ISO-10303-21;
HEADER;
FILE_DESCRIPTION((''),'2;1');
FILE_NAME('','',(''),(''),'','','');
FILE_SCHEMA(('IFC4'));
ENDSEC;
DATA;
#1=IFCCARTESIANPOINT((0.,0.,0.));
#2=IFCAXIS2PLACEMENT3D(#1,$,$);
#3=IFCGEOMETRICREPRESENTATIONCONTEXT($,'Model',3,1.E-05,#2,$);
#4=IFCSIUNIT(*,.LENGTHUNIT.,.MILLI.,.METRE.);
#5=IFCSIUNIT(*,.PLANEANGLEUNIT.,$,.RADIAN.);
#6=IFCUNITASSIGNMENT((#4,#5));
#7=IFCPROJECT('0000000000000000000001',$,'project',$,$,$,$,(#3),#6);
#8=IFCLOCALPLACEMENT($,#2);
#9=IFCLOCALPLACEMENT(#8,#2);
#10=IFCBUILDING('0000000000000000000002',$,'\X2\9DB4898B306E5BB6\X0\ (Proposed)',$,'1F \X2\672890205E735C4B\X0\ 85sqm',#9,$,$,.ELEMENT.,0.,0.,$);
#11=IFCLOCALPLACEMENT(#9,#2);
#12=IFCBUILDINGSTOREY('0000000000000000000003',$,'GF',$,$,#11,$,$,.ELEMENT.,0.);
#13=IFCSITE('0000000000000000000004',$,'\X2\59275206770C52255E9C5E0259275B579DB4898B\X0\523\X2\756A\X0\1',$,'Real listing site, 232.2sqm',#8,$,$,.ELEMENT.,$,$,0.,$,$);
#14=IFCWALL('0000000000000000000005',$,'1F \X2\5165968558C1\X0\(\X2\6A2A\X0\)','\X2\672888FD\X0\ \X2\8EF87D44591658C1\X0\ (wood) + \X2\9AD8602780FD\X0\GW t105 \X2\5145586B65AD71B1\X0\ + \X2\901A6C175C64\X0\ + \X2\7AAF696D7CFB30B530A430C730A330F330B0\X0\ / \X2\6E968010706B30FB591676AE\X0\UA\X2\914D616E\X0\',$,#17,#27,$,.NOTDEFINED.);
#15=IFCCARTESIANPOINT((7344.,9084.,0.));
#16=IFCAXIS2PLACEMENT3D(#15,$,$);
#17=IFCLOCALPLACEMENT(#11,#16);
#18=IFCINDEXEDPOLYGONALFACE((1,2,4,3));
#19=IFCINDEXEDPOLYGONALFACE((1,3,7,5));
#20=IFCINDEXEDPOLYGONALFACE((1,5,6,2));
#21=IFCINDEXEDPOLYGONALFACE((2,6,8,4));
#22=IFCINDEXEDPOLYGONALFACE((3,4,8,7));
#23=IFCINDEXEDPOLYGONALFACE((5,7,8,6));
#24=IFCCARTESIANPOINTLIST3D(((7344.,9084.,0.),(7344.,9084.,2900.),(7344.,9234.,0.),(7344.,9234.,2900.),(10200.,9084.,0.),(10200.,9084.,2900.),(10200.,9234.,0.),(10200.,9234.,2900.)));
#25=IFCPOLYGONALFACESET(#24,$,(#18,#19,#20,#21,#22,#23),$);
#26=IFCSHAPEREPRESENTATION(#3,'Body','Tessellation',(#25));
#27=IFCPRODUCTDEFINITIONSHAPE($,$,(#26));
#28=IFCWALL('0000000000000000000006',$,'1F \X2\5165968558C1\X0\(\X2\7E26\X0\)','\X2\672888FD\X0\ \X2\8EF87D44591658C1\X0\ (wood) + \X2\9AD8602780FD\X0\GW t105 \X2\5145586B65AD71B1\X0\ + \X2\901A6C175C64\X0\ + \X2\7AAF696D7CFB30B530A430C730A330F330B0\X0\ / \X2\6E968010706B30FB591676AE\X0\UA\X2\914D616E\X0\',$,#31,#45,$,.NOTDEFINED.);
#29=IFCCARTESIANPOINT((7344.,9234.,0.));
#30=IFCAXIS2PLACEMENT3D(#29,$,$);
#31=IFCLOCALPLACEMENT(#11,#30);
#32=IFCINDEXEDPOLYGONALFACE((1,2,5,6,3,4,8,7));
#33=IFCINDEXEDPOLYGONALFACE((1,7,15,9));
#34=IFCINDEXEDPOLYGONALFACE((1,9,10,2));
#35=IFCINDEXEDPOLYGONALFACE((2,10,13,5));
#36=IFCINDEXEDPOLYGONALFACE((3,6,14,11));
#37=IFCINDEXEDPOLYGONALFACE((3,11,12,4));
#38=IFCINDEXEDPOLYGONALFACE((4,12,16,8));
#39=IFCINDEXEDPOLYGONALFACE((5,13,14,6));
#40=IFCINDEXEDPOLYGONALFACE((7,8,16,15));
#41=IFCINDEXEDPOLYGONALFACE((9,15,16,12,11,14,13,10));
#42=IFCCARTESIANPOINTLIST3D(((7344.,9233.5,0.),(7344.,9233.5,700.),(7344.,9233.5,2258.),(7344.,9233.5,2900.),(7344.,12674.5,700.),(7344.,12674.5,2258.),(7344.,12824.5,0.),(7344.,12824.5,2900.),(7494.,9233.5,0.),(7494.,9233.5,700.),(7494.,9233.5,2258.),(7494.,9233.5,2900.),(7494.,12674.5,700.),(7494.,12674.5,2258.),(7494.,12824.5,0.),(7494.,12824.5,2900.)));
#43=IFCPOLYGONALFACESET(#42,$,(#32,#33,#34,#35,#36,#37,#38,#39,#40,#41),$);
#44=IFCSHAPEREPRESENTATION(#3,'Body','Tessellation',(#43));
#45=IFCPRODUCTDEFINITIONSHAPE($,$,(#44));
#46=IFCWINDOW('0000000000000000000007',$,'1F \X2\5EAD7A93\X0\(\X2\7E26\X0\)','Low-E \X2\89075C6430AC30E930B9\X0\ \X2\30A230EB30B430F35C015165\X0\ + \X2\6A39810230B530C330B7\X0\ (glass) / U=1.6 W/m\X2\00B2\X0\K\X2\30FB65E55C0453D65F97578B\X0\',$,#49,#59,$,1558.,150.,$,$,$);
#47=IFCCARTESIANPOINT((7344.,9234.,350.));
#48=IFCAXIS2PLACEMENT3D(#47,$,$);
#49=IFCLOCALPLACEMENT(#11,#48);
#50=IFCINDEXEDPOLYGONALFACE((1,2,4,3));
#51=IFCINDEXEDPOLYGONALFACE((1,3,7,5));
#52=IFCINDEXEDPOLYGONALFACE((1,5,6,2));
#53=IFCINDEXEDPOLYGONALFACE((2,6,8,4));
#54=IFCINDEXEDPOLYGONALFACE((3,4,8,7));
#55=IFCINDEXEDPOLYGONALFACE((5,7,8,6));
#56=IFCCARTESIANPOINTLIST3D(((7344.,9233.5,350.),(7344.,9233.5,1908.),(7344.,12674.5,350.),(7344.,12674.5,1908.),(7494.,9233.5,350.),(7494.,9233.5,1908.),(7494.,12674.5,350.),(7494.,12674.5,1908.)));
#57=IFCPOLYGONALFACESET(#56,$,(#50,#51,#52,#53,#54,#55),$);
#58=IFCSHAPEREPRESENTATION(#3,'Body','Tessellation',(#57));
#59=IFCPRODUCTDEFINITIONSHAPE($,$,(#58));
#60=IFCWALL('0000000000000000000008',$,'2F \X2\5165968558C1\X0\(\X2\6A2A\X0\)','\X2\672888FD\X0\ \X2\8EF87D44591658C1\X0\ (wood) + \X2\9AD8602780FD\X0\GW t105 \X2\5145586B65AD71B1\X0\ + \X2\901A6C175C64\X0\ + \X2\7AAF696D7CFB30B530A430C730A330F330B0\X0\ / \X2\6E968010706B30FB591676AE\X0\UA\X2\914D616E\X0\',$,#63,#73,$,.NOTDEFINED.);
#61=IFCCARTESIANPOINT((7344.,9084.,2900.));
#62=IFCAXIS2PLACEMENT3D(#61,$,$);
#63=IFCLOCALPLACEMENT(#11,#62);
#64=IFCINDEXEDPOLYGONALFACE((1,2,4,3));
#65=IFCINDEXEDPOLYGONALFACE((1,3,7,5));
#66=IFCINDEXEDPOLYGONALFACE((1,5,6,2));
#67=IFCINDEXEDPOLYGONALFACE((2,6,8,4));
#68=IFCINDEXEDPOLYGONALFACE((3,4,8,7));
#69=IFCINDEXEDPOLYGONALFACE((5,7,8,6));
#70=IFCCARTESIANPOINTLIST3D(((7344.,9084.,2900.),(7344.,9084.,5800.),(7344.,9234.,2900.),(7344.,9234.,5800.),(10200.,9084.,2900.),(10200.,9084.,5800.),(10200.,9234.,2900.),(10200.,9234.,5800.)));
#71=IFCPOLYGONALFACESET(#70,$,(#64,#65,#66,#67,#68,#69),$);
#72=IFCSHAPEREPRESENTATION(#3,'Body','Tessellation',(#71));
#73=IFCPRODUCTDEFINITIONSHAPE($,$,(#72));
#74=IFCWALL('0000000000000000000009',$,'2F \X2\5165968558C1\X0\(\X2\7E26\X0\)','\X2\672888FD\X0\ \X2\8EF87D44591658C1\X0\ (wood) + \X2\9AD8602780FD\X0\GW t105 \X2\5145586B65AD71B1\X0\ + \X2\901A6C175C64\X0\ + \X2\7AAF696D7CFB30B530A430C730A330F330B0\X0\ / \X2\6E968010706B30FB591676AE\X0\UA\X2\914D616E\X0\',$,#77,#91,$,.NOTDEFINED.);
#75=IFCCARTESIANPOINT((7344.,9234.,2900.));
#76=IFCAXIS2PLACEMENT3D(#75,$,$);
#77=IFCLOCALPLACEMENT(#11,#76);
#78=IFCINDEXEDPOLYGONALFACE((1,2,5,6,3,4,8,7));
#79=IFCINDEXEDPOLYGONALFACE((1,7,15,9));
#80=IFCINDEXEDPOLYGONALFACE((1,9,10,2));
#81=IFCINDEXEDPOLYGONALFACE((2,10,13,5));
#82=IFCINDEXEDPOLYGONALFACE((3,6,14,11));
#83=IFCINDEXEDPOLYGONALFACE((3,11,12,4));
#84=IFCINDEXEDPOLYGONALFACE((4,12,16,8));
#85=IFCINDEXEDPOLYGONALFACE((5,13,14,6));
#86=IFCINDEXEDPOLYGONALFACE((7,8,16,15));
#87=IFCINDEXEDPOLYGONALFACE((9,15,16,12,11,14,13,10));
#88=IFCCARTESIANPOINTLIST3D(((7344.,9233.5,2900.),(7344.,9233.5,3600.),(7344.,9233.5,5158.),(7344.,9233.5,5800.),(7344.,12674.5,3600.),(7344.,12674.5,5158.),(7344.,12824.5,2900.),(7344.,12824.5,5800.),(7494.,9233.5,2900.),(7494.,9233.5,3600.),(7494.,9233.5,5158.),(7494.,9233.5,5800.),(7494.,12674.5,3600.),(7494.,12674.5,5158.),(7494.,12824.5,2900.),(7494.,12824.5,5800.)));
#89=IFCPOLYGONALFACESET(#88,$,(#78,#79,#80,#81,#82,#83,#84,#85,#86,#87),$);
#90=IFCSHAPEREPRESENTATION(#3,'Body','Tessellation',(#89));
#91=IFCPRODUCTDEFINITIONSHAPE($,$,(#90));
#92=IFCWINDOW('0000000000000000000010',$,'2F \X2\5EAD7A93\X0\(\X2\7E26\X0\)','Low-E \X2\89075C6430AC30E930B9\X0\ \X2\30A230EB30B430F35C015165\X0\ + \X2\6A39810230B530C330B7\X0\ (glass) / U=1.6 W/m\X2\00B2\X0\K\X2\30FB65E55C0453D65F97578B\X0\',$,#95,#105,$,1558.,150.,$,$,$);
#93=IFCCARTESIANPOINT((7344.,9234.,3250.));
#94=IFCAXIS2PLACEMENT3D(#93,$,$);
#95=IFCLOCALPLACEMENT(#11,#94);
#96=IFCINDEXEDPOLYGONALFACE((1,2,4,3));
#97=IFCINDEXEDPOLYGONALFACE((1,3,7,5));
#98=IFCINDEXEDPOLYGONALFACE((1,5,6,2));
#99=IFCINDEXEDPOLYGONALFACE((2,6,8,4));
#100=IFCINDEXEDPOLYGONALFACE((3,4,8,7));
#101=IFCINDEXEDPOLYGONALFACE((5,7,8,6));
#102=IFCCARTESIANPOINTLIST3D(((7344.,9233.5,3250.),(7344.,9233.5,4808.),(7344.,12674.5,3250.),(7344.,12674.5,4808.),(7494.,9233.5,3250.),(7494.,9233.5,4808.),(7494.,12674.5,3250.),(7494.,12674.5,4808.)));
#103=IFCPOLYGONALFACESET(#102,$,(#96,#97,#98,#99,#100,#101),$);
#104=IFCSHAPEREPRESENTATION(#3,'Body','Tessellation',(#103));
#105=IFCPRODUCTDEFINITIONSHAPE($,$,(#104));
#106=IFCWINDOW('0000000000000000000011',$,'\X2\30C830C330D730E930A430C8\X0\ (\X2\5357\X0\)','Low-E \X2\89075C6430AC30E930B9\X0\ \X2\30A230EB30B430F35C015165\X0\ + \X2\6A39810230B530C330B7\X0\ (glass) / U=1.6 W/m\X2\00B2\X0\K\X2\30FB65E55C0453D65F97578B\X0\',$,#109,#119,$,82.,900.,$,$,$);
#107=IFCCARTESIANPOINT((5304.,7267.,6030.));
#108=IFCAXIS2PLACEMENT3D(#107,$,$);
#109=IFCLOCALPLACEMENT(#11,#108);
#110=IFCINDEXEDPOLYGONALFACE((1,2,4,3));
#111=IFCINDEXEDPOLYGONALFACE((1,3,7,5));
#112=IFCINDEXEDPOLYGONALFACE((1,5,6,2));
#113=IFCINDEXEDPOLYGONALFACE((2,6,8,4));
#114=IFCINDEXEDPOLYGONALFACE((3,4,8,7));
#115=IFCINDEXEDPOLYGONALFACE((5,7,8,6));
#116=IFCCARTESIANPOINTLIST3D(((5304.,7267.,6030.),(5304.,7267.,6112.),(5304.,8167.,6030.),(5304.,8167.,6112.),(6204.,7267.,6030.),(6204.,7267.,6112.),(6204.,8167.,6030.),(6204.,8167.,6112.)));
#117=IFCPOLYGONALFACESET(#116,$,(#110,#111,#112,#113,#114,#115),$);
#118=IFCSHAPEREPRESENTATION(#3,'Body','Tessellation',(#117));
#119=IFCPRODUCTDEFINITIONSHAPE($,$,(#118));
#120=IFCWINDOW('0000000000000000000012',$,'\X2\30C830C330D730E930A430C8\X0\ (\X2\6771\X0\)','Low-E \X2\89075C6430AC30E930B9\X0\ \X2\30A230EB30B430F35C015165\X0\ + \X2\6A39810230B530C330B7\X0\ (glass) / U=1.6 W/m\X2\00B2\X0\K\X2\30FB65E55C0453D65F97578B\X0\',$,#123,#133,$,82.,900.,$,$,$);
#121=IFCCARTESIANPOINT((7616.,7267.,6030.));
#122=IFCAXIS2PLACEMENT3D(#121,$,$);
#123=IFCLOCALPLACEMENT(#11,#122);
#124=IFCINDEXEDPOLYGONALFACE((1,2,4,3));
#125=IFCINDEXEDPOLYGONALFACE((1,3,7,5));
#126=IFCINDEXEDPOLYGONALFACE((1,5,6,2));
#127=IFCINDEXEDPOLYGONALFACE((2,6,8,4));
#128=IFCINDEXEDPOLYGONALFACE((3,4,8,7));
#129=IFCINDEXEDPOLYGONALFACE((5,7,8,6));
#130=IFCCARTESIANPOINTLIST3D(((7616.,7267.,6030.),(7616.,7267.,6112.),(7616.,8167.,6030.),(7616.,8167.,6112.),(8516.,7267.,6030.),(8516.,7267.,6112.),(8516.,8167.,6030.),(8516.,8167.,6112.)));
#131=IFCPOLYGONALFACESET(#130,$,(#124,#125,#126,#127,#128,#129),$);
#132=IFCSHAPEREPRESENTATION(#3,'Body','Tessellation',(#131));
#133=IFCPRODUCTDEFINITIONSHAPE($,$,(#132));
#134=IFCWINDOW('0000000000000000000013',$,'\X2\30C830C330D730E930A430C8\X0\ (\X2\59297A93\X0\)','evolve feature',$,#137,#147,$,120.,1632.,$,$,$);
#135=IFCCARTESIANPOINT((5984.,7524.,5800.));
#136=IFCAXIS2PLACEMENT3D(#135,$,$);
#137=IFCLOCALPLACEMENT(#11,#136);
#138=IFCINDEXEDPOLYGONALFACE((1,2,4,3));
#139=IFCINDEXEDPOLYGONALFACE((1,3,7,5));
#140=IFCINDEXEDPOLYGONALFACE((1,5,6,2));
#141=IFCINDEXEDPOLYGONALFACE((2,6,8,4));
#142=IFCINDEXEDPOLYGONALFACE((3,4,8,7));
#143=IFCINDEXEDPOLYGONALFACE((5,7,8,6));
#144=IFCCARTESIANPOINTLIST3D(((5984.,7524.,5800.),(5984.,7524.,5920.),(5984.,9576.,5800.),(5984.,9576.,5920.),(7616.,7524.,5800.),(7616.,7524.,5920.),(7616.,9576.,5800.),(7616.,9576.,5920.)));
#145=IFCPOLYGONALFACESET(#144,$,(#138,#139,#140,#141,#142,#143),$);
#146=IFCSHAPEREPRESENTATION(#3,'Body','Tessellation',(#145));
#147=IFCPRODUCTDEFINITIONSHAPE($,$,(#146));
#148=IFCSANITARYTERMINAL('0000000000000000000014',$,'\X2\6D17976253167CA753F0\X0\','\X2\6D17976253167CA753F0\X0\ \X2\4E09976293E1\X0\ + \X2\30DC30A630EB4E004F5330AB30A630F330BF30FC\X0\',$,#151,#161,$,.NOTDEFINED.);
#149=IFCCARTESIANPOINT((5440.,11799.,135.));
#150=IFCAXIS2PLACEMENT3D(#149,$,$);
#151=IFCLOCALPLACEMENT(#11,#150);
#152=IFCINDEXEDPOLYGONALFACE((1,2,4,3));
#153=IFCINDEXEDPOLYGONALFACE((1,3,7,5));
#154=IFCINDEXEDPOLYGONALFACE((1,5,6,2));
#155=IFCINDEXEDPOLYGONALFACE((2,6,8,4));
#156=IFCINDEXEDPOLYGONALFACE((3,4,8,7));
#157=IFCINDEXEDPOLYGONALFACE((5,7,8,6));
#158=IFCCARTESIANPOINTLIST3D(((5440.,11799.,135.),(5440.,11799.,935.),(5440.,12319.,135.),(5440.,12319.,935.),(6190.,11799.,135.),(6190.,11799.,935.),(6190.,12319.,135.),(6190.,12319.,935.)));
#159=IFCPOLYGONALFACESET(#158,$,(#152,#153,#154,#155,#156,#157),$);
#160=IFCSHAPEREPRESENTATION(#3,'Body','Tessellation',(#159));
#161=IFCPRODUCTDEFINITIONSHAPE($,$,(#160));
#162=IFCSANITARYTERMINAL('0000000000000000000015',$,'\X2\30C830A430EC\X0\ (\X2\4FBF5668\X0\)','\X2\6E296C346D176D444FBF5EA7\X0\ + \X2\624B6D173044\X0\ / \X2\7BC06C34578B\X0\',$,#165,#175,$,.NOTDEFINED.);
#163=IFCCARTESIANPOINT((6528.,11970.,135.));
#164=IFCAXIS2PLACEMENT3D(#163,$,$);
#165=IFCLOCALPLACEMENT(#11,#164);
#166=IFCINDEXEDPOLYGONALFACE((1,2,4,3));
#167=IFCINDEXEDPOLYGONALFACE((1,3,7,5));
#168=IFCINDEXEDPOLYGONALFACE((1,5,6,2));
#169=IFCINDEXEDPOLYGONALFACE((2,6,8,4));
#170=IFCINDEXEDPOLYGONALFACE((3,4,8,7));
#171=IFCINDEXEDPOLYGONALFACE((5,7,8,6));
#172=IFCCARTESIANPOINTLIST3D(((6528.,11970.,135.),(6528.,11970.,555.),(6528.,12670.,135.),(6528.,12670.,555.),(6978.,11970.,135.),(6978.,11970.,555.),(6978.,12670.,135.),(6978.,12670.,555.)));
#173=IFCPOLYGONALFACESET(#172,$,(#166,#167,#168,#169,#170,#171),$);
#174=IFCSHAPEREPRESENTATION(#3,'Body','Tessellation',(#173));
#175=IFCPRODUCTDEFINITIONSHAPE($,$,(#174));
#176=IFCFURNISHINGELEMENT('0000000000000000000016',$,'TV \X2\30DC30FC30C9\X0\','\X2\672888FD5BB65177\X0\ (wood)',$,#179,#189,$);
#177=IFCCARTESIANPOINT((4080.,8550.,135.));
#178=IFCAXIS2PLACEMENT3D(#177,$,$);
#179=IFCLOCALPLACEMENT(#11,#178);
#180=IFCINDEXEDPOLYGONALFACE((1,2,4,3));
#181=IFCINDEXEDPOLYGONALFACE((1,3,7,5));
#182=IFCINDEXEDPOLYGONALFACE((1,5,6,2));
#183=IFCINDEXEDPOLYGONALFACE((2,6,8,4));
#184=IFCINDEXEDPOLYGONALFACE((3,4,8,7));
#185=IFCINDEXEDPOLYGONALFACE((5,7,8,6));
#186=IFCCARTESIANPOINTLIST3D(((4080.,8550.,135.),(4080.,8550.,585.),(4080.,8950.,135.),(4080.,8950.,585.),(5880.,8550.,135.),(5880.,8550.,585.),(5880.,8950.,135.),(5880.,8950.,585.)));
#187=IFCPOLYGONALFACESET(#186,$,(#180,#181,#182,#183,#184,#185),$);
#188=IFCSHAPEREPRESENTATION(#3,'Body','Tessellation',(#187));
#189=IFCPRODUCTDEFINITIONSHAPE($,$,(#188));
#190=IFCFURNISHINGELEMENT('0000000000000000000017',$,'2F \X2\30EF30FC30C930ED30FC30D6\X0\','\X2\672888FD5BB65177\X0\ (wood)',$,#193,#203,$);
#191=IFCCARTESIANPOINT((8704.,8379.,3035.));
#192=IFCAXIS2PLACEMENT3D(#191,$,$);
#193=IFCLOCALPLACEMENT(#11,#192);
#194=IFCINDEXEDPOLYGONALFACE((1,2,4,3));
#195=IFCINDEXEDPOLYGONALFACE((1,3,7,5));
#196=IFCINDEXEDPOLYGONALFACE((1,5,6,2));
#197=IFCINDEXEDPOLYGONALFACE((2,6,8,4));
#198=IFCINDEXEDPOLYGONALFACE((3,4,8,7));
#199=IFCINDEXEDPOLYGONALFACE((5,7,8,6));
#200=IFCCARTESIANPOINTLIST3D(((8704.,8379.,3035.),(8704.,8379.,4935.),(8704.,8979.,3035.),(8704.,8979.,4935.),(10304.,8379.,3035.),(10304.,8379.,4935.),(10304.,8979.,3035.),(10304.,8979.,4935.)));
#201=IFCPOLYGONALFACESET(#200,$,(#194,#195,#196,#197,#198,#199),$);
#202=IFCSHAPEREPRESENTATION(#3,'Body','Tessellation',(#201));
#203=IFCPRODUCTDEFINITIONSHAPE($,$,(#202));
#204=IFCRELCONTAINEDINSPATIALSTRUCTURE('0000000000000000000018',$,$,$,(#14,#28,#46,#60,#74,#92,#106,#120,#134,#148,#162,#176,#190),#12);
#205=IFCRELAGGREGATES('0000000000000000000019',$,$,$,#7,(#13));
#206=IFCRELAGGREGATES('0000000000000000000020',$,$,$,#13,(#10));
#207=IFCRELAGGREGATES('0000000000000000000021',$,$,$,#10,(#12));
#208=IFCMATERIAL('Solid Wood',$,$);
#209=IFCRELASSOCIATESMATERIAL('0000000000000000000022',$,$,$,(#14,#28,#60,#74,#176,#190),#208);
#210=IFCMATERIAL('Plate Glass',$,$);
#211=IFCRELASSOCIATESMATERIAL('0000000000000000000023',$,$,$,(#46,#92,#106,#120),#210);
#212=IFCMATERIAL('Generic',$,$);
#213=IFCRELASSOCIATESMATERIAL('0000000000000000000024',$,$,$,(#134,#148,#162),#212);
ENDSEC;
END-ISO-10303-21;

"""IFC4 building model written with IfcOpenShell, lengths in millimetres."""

from ifc_helpers import new_model, si_unit, frame, frame_2d, origin, place, context, project, spatial, rectangle, extrude, material, element, fill, save


model = new_model("IFC4")

# Units and contexts
model_context = context("Model", 3, precision=1e-05, world=origin())
ifc_project = project(units=[si_unit("LENGTHUNIT", "METRE", prefix="MILLI"), si_unit("PLANEANGLEUNIT", "RADIAN")], contexts=[model_context])

# Site, building, storey
site_placement = place(None, origin())
site = spatial("IfcSite", under=ifc_project, at=site_placement, Name="大分県別府市大字鶴見523番1", ObjectType="Real listing site, 232.2sqm", CompositionType="ELEMENT", RefElevation=0.0)
building_placement = place(site_placement, origin())
building = spatial("IfcBuilding", under=site, at=building_placement, Name="鶴見の家 (Proposed)", ObjectType="1F 木造平屋 85sqm", CompositionType="ELEMENT", ElevationOfRefHeight=0.0, ElevationOfTerrain=0.0)
storey_placement = place(building_placement, origin())
storey = spatial("IfcBuildingStorey", under=building, at=storey_placement, Name="GF", CompositionType="ELEMENT", Elevation=0.0)

# Shared definitions
ifc_material_1 = material(Name="Solid Wood")

# Wall
wall_1_placement = place(storey_placement, frame((7344.0, 9084.0, 0.0)))
element("IfcWall", 1, at=wall_1_placement, inside=storey, material=ifc_material_1, Name="1F 入隅壁(横)", Description="木製 軸組外壁 (wood) + 高性能GW t105 充填断熱 + 通気層 + 窯業系サイディング / 準耐火・外皮UA配慮", PredefinedType="NOTDEFINED", context=model_context, shape_type="SweptSolid", body=[
    extrude(rectangle(XDim=2856.0, YDim=150.0, at=frame_2d((1428.0, 75.0))), frame((7344.0, 9084.0, 0.0)), (0.0, 0.0, 1.0), 2900.0),
])

# Wall, opening, window
wall_2_placement = place(storey_placement, frame((7344.0, 9234.0, 0.0)))
wall_2 = element("IfcWall", 2, at=wall_2_placement, inside=storey, material=ifc_material_1, Name="1F 入隅壁(縦)", Description="木製 軸組外壁 (wood) + 高性能GW t105 充填断熱 + 通気層 + 窯業系サイディング / 準耐火・外皮UA配慮", PredefinedType="NOTDEFINED", context=model_context, shape_type="SweptSolid", body=[
    extrude(rectangle(XDim=150.0, YDim=3591.0, at=frame_2d((75.0, 1795.0))), frame((7344.0, 9234.0, 0.0)), (0.0, 0.0, 1.0), 2900.0),
])
opening_1_placement = place(storey_placement, frame((7344.0, 9234.0, 350.0)))
opening_1 = element("IfcOpeningElement", 3, at=opening_1_placement, cuts=wall_2, PredefinedType="NOTDEFINED", context=model_context, shape_type="SweptSolid", body=[
    extrude(rectangle(XDim=150.0, YDim=3441.0, at=frame_2d((75.0, 1720.0))), frame((7344.0, 9234.0, 350.0)), (0.0, 0.0, 1.0), 1558.0),
])
ifc_material_2 = material(Name="Plate Glass")
window_1_placement = place(storey_placement, frame((7344.0, 9234.0, 350.0)))
window_1 = element("IfcWindow", 4, at=window_1_placement, inside=storey, material=ifc_material_2, Name="1F 庭窓(縦)", Description="Low-E 複層ガラス アルゴン封入 + 樹脂サッシ (glass) / U=1.6 W/m²K・日射取得型", OverallHeight=1558.0, OverallWidth=150.0, context=model_context, shape_type="SweptSolid", body=[
    extrude(rectangle(XDim=150.0, YDim=3441.0, at=frame_2d((75.0, 1720.0))), frame((7344.0, 9234.0, 350.0)), (0.0, 0.0, 1.0), 1558.0),
])
fill(opening_1, window_1)

# Wall
wall_3_placement = place(storey_placement, frame((7344.0, 9084.0, 2900.0)))
element("IfcWall", 5, at=wall_3_placement, inside=storey, material=ifc_material_1, Name="2F 入隅壁(横)", Description="木製 軸組外壁 (wood) + 高性能GW t105 充填断熱 + 通気層 + 窯業系サイディング / 準耐火・外皮UA配慮", PredefinedType="NOTDEFINED", context=model_context, shape_type="SweptSolid", body=[
    extrude(rectangle(XDim=2856.0, YDim=150.0, at=frame_2d((1428.0, 75.0))), frame((7344.0, 9084.0, 2900.0)), (0.0, 0.0, 1.0), 2900.0),
])

# Wall, opening, window
wall_4_placement = place(storey_placement, frame((7344.0, 9234.0, 2900.0)))
wall_4 = element("IfcWall", 6, at=wall_4_placement, inside=storey, material=ifc_material_1, Name="2F 入隅壁(縦)", Description="木製 軸組外壁 (wood) + 高性能GW t105 充填断熱 + 通気層 + 窯業系サイディング / 準耐火・外皮UA配慮", PredefinedType="NOTDEFINED", context=model_context, shape_type="SweptSolid", body=[
    extrude(rectangle(XDim=150.0, YDim=3591.0, at=frame_2d((75.0, 1795.0))), frame((7344.0, 9234.0, 2900.0)), (0.0, 0.0, 1.0), 2900.0),
])
opening_2_placement = place(storey_placement, frame((7344.0, 9234.0, 3250.0)))
opening_2 = element("IfcOpeningElement", 7, at=opening_2_placement, cuts=wall_4, PredefinedType="NOTDEFINED", context=model_context, shape_type="SweptSolid", body=[
    extrude(rectangle(XDim=150.0, YDim=3441.0, at=frame_2d((75.0, 1720.0))), frame((7344.0, 9234.0, 3250.0)), (0.0, 0.0, 1.0), 1558.0),
])
window_2_placement = place(storey_placement, frame((7344.0, 9234.0, 3250.0)))
window_2 = element("IfcWindow", 8, at=window_2_placement, inside=storey, material=ifc_material_2, Name="2F 庭窓(縦)", Description="Low-E 複層ガラス アルゴン封入 + 樹脂サッシ (glass) / U=1.6 W/m²K・日射取得型", OverallHeight=1558.0, OverallWidth=150.0, context=model_context, shape_type="SweptSolid", body=[
    extrude(rectangle(XDim=150.0, YDim=3441.0, at=frame_2d((75.0, 1720.0))), frame((7344.0, 9234.0, 3250.0)), (0.0, 0.0, 1.0), 1558.0),
])
fill(opening_2, window_2)

# Windows
window_3_placement = place(storey_placement, frame((5304.0, 7267.0, 6030.0)))
element("IfcWindow", 9, at=window_3_placement, inside=storey, material=ifc_material_2, Name="トップライト (南)", Description="Low-E 複層ガラス アルゴン封入 + 樹脂サッシ (glass) / U=1.6 W/m²K・日射取得型", OverallHeight=82.0, OverallWidth=900.0, context=model_context, shape_type="SweptSolid", body=[
    extrude(rectangle(XDim=900.0, YDim=900.0, at=frame_2d((450.0, 450.0))), frame((5304.0, 7267.0, 6030.0)), (0.0, 0.0, 1.0), 82.0),
])
window_4_placement = place(storey_placement, frame((7616.0, 7267.0, 6030.0)))
element("IfcWindow", 10, at=window_4_placement, inside=storey, material=ifc_material_2, Name="トップライト (東)", Description="Low-E 複層ガラス アルゴン封入 + 樹脂サッシ (glass) / U=1.6 W/m²K・日射取得型", OverallHeight=82.0, OverallWidth=900.0, context=model_context, shape_type="SweptSolid", body=[
    extrude(rectangle(XDim=900.0, YDim=900.0, at=frame_2d((450.0, 450.0))), frame((7616.0, 7267.0, 6030.0)), (0.0, 0.0, 1.0), 82.0),
])
ifc_material_3 = material(Name="Generic")
window_5_placement = place(storey_placement, frame((5984.0, 7524.0, 5800.0)))
element("IfcWindow", 11, at=window_5_placement, inside=storey, material=ifc_material_3, Name="トップライト (天窓)", Description="evolve feature", OverallHeight=120.0, OverallWidth=1632.0, context=model_context, shape_type="SweptSolid", body=[
    extrude(rectangle(XDim=1632.0, YDim=2052.0, at=frame_2d((816.0, 1026.0))), frame((5984.0, 7524.0, 5800.0)), (0.0, 0.0, 1.0), 120.0),
])

# Sanitary terminals
sanitary_terminal_1_placement = place(storey_placement, frame((5440.0, 11799.0, 135.0)))
element("IfcSanitaryTerminal", 12, at=sanitary_terminal_1_placement, inside=storey, material=ifc_material_3, Name="洗面化粧台", Description="洗面化粧台 三面鏡 + ボウル一体カウンター", PredefinedType="NOTDEFINED", context=model_context, shape_type="SweptSolid", body=[
    extrude(rectangle(XDim=750.0, YDim=520.0, at=frame_2d((375.0, 260.0))), frame((5440.0, 11799.0, 135.0)), (0.0, 0.0, 1.0), 800.0),
])
sanitary_terminal_2_placement = place(storey_placement, frame((6528.0, 11970.0, 135.0)))
element("IfcSanitaryTerminal", 13, at=sanitary_terminal_2_placement, inside=storey, material=ifc_material_3, Name="トイレ (便器)", Description="温水洗浄便座 + 手洗い / 節水型", PredefinedType="NOTDEFINED", context=model_context, shape_type="SweptSolid", body=[
    extrude(rectangle(XDim=450.0, YDim=700.0, at=frame_2d((225.0, 350.0))), frame((6528.0, 11970.0, 135.0)), (0.0, 0.0, 1.0), 420.0),
])

# Furnishing elements
furnishing_1_placement = place(storey_placement, frame((4080.0, 8550.0, 135.0)))
element("IfcFurnishingElement", 14, at=furnishing_1_placement, inside=storey, material=ifc_material_1, Name="TV ボード", Description="木製家具 (wood)", context=model_context, shape_type="SweptSolid", body=[
    extrude(rectangle(XDim=1800.0, YDim=400.0, at=frame_2d((900.0, 200.0))), frame((4080.0, 8550.0, 135.0)), (0.0, 0.0, 1.0), 450.0),
])
furnishing_2_placement = place(storey_placement, frame((8704.0, 8379.0, 3035.0)))
element("IfcFurnishingElement", 15, at=furnishing_2_placement, inside=storey, material=ifc_material_1, Name="2F ワードローブ", Description="木製家具 (wood)", context=model_context, shape_type="SweptSolid", body=[
    extrude(rectangle(XDim=1600.0, YDim=600.0, at=frame_2d((800.0, 300.0))), frame((8704.0, 8379.0, 3035.0)), (0.0, 0.0, 1.0), 1900.0),
])

save(model, "model.ifc")
